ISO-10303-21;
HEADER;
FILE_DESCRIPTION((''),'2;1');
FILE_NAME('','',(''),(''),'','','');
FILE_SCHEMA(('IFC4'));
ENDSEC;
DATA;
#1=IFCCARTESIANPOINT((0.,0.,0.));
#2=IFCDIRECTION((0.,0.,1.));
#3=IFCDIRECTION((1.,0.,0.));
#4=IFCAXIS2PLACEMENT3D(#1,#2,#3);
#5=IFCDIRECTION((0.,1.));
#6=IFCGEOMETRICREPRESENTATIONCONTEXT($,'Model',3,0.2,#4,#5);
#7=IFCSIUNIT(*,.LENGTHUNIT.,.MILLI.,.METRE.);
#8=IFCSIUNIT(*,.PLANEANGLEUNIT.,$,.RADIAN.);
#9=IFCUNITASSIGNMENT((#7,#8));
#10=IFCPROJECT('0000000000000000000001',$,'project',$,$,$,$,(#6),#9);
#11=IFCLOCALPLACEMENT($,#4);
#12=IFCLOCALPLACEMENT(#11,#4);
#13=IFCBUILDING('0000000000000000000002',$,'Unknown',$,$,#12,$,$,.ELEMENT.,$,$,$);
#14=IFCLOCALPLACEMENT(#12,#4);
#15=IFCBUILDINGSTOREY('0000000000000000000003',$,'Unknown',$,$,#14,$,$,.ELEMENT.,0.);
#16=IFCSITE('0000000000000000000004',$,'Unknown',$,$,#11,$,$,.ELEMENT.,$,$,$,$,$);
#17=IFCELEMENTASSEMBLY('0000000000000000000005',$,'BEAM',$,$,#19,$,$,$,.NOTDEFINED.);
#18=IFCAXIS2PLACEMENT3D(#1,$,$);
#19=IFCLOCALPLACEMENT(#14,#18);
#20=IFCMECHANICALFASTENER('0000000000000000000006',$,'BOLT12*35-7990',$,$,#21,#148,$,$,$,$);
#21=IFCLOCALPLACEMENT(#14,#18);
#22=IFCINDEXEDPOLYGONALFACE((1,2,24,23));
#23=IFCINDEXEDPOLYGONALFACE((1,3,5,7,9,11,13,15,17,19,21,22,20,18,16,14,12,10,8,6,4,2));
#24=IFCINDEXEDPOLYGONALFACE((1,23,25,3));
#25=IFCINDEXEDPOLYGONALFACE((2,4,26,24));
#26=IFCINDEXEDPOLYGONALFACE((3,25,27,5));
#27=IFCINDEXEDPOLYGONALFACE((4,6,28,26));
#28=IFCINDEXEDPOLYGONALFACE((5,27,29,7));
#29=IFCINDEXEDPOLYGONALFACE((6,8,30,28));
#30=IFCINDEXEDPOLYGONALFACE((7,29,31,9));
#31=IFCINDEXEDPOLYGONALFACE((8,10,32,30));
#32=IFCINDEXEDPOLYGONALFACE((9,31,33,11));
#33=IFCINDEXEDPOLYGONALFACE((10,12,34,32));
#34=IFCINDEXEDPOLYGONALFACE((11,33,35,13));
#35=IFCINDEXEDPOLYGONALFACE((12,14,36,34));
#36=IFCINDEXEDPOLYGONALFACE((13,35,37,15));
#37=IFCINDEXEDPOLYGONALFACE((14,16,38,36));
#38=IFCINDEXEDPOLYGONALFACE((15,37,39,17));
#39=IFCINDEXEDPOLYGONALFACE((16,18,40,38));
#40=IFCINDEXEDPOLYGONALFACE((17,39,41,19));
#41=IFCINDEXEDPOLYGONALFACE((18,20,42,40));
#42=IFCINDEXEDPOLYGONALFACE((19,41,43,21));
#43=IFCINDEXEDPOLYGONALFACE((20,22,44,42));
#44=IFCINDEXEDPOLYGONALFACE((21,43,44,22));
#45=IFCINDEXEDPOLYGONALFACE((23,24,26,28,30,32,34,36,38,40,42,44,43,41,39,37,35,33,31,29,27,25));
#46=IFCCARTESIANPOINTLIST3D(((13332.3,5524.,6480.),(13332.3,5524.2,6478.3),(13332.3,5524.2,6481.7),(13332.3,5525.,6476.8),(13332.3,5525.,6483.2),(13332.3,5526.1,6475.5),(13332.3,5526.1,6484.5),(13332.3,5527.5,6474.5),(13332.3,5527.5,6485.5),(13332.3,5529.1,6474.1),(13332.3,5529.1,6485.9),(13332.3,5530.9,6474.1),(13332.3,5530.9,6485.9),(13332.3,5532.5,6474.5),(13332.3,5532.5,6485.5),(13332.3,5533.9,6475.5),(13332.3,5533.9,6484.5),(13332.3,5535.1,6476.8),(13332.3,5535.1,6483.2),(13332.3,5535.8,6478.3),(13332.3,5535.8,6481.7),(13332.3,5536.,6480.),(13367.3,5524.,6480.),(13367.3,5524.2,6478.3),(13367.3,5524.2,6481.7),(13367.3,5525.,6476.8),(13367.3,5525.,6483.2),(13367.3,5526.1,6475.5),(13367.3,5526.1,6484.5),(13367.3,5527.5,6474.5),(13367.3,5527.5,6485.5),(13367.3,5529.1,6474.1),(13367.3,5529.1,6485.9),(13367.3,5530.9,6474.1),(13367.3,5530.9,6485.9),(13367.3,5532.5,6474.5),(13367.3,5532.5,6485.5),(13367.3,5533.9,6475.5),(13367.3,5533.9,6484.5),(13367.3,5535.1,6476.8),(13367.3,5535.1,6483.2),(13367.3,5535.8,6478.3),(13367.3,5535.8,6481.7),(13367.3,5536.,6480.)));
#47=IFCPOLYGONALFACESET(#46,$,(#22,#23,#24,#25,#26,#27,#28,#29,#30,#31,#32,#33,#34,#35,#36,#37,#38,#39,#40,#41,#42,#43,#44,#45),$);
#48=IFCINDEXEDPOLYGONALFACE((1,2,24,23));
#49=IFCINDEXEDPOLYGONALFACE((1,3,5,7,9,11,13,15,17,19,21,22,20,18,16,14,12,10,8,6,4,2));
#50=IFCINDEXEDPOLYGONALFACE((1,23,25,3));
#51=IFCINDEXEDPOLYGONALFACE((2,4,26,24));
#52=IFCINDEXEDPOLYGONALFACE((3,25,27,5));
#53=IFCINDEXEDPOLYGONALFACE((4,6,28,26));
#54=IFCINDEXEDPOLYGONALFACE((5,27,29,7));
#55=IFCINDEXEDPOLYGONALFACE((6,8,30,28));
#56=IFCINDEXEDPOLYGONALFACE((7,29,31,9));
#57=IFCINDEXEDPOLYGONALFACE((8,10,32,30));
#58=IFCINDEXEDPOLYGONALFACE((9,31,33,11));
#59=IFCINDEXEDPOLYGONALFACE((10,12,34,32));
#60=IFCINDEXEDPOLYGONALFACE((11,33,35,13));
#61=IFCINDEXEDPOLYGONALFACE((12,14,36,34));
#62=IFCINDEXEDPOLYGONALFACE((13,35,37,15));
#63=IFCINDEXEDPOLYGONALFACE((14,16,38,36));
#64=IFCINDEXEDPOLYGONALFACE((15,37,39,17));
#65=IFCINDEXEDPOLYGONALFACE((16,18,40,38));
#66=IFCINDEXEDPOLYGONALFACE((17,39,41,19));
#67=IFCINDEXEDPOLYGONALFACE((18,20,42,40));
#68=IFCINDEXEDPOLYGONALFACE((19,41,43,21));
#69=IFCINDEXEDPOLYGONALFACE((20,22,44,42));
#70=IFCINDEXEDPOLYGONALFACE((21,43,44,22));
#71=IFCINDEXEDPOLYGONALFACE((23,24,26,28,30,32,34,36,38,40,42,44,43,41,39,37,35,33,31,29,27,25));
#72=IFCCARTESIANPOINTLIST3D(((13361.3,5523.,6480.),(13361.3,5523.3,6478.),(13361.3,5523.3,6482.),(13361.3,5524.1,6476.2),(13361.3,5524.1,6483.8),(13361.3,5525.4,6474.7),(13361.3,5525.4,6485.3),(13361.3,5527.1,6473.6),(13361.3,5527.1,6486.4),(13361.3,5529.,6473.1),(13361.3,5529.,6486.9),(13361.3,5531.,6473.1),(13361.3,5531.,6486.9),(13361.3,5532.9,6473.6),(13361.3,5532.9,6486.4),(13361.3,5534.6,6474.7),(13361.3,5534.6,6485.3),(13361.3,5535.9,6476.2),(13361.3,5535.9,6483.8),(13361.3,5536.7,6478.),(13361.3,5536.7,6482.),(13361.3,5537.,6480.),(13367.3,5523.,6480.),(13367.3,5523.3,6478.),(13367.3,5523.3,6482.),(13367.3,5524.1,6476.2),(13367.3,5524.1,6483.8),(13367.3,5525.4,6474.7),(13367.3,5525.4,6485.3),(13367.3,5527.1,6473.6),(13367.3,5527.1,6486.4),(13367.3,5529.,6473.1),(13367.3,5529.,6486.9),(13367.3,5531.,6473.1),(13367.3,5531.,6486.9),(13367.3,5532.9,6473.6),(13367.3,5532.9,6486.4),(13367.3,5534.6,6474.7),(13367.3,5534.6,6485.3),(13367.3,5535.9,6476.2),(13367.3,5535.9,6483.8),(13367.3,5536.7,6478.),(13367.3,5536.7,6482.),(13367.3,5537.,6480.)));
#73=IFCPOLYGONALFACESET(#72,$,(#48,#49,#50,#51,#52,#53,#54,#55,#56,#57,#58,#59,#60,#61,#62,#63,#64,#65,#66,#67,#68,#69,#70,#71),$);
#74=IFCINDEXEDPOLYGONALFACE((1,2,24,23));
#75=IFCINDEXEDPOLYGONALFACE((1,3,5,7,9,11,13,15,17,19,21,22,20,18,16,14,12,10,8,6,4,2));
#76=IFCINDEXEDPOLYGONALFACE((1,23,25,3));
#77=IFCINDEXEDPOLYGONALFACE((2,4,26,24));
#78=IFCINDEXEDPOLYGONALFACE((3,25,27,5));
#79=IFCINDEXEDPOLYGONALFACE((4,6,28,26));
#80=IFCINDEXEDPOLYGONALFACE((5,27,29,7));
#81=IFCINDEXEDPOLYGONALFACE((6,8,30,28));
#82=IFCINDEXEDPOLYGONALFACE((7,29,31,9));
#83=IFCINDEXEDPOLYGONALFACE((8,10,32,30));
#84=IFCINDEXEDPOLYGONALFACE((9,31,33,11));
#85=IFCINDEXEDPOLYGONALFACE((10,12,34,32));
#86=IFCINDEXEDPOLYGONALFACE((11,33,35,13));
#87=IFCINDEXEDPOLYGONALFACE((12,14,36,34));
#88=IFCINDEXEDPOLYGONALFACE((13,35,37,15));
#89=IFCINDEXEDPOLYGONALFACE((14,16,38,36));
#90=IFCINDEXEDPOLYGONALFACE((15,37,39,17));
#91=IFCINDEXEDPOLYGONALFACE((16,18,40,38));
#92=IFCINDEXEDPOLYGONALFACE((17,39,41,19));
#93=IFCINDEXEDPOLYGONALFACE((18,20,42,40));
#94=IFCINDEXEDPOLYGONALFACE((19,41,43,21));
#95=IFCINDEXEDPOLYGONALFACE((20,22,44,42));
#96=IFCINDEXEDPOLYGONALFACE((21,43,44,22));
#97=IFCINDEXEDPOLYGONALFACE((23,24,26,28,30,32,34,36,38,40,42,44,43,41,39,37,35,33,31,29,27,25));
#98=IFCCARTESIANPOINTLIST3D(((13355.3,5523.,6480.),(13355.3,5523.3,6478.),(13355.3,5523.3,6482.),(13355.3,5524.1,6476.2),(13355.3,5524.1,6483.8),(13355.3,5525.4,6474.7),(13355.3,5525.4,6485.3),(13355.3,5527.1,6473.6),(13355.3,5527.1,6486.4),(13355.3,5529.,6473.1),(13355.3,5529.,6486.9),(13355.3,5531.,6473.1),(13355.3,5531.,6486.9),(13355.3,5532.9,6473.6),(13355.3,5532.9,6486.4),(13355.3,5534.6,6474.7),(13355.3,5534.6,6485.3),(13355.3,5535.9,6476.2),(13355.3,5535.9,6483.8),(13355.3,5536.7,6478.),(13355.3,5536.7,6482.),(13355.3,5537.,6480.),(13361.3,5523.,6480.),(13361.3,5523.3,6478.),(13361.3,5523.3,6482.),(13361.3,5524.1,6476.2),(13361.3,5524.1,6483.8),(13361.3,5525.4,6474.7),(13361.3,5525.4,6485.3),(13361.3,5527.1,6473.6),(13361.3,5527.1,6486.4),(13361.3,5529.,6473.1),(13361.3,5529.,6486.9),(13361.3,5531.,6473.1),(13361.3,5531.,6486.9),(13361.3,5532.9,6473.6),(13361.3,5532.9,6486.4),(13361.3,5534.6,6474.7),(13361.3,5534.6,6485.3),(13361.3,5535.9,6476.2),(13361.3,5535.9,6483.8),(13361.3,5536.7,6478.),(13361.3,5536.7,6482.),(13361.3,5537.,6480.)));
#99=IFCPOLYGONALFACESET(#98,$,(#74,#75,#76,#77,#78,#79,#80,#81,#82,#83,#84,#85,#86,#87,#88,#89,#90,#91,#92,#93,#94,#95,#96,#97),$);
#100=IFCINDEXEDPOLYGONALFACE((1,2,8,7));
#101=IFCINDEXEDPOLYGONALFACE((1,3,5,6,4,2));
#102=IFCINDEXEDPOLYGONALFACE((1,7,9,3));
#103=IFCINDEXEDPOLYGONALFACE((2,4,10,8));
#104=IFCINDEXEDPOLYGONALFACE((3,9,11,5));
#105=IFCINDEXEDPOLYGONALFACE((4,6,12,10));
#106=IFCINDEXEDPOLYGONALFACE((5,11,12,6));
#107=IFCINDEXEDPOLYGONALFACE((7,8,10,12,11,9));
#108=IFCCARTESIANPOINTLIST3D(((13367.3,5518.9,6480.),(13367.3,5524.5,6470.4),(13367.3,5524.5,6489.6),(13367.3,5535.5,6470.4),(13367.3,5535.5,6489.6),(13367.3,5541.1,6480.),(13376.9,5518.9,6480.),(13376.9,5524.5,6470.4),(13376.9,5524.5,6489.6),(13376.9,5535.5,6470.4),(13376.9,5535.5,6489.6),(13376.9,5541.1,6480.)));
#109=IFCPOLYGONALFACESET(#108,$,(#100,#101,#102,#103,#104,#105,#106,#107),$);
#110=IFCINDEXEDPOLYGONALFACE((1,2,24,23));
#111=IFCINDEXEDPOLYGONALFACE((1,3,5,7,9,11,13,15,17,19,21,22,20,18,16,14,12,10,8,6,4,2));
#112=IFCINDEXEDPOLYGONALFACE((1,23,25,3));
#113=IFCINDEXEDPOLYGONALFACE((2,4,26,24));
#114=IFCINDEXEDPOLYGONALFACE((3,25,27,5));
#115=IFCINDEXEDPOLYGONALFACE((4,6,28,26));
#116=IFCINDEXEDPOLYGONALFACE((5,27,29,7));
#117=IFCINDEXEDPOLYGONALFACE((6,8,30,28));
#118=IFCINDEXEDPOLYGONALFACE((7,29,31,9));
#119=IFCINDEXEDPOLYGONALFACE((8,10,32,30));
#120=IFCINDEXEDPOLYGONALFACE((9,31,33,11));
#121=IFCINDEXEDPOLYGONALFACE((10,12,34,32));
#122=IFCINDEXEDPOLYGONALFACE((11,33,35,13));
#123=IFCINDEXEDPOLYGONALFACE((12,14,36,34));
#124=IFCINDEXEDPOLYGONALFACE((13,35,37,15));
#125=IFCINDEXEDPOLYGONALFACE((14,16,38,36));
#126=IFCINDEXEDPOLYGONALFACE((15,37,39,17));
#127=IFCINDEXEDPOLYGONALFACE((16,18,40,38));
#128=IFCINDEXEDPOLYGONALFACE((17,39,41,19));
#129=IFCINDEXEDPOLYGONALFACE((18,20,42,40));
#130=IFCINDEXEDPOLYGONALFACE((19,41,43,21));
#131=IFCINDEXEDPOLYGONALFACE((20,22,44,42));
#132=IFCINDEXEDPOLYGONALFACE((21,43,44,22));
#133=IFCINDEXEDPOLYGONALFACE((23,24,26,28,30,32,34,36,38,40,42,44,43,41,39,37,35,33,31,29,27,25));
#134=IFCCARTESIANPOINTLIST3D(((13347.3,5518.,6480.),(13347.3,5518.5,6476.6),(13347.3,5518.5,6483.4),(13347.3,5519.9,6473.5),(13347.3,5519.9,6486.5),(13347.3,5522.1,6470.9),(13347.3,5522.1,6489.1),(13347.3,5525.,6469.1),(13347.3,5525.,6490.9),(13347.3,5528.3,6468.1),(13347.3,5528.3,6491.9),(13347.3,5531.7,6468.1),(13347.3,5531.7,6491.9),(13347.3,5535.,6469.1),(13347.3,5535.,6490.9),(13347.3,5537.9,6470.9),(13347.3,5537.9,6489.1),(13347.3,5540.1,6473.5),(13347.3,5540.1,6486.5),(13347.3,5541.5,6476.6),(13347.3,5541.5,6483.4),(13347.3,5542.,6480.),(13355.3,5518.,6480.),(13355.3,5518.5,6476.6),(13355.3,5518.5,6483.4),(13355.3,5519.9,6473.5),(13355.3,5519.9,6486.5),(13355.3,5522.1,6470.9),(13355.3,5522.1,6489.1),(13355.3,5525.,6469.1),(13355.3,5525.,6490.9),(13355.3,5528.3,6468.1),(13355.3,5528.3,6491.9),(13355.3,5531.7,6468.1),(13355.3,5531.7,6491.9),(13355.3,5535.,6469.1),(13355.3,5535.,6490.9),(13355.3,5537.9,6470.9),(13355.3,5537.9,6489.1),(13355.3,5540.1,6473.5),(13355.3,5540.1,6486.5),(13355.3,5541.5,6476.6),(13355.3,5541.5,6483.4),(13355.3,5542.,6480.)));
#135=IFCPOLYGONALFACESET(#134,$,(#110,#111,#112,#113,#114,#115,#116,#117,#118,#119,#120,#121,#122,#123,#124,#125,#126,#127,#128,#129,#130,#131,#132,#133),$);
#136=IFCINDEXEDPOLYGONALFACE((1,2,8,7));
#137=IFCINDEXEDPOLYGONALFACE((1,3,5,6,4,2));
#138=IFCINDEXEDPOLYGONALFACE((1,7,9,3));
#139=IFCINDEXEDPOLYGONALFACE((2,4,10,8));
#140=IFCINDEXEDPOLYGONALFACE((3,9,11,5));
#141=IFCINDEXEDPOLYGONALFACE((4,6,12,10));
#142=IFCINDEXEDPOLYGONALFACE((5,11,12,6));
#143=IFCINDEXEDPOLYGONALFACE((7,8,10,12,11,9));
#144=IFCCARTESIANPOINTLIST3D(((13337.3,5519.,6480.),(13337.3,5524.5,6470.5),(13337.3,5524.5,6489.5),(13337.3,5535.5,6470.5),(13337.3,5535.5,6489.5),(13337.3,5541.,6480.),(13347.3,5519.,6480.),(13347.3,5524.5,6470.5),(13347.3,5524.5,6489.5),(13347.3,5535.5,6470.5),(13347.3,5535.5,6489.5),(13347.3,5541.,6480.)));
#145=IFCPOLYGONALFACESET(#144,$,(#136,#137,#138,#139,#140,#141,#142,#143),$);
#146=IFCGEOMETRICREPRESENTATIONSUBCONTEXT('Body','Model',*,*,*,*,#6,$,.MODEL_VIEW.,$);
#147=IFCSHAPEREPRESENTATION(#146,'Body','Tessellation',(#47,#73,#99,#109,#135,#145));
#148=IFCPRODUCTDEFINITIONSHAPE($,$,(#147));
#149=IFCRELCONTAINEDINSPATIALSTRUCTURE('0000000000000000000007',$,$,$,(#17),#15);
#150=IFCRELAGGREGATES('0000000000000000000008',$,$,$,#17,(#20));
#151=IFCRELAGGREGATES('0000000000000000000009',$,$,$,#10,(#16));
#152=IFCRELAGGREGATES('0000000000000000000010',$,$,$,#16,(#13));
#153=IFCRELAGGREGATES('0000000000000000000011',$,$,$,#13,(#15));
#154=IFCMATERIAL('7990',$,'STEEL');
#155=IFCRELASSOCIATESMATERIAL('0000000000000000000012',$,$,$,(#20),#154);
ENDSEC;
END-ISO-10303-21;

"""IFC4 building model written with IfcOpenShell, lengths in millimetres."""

from ifc_helpers import new_model, si_unit, direction, frame, origin_with_axes, place, context, subcontext, project, spatial, line, arc, indexed_curve, outline, extrude, source, transform, mapped, material, element, aggregate, save


model = new_model("IFC4")

# Units and contexts
model_context = context("Model", 3, precision=0.2, world=origin_with_axes(), true_north=direction((0.0, 1.0)))
body_context = subcontext(model_context, "Body", "Model", "MODEL_VIEW")
ifc_project = project(units=[si_unit("LENGTHUNIT", "METRE", prefix="MILLI"), si_unit("PLANEANGLEUNIT", "RADIAN")], contexts=[model_context])

# Site, building, storey
site_placement = place(None, origin_with_axes())
site = spatial("IfcSite", under=ifc_project, at=site_placement, Name="Unknown", CompositionType="ELEMENT")
building_placement = place(site_placement, origin_with_axes())
building = spatial("IfcBuilding", under=site, at=building_placement, Name="Unknown", CompositionType="ELEMENT")
storey_placement = place(building_placement, origin_with_axes())
storey = spatial("IfcBuildingStorey", under=building, at=storey_placement, Name="Unknown", CompositionType="ELEMENT", Elevation=0.0)

# Element assembly
assembly_1_placement = place(storey_placement, frame((13376.3, 5500.0, 6980.0), z_axis=(-1.0, 0.0, 0.0), x_axis=(0.0, -1.0, 0.000002)))
assembly_1 = element("IfcElementAssembly", 1, at=assembly_1_placement, inside=storey, Name="BEAM", PredefinedType="NOTDEFINED")

# Mechanical fastener
ifc_material_1 = material(Name="7990", Category="STEEL")
shared_shape_1 = source(origin_with_axes(), body_context, "Body", "SweptSolid", [
    extrude(outline(indexed_curve([(6.0, 0.0), (0.0, 6.0), (-6.0, 0.0), (0.0, -6.0)], segments=[arc(1, 2, 3), arc(3, 4, 1)])), frame((0.0, 0.0, 6.0), z_axis=(0.0, -0.000002, -1.0), x_axis=(0.0, 1.0, 0.0)), (0.0, 0.0, 1.0), 35.0),
    extrude(outline(indexed_curve([(7.0, 0.0), (0.0, 7.0), (-7.0, 0.0), (0.0, -7.0)], segments=[arc(1, 2, 3), arc(3, 4, 1)])), frame((0.0, 0.0, 6.0), z_axis=(0.0, -0.000002, -1.0), x_axis=(0.0, 1.0, 0.0)), (0.0, 0.0, 1.0), 6.0),
    extrude(outline(indexed_curve([(7.0, 0.0), (0.0, 7.0), (-7.0, 0.0), (0.0, -7.0)], segments=[arc(1, 2, 3), arc(3, 4, 1)])), frame((0.0, 0.0, 0.0), z_axis=(0.0, -0.000002, -1.0), x_axis=(0.0, 1.0, 0.0)), (0.0, 0.0, 1.0), 6.0),
    extrude(outline(indexed_curve([(11.1, 0.0), (5.5, 9.6), (-5.5, 9.6), (-11.1, 0.0), (-5.5, -9.6), (5.5, -9.6)], segments=[line(1, 2, 3, 4, 5, 6, 1)])), frame((0.0, 0.0, 15.6), z_axis=(0.0, -0.000002, -1.0), x_axis=(0.0, 1.0, 0.0)), (0.0, 0.0, 1.0), 9.6),
    extrude(outline(indexed_curve([(12.0, 0.0), (0.0, 12.0), (-12.0, 0.0), (0.0, -12.0)], segments=[arc(1, 2, 3), arc(3, 4, 1)])), frame((0.0, 0.0, -6.0), z_axis=(0.0, -0.000002, -1.0), x_axis=(0.0, 1.0, 0.0)), (0.0, 0.0, 1.0), 8.0),
    extrude(outline(indexed_curve([(11.0, 0.0), (5.5, 9.5), (-5.5, 9.5), (-11.0, 0.0), (-5.5, -9.5), (5.5, -9.5)], segments=[line(1, 2, 3, 4, 5, 6, 1)])), frame((0.0, 0.0, -14.0), z_axis=(0.0, -0.000002, -1.0), x_axis=(0.0, 1.0, 0.0)), (0.0, 0.0, 1.0), 10.0),
])
mechanical_fastener_1_placement = place(assembly_1_placement, frame((-30.0, -500.0, 15.0), z_axis=(0.0, -0.000002, -1.0), x_axis=(0.0, -1.0, 0.000002)))
mechanical_fastener_1 = element("IfcMechanicalFastener", 2, at=mechanical_fastener_1_placement, material=ifc_material_1, Name="BOLT12*35-7990", context=body_context, shape_type="MappedRepresentation", body=[
    mapped(shared_shape_1, transform((0.0, 0.0, 0.0))),
])
aggregate(assembly_1, [mechanical_fastener_1])

save(model, "model.ifc")
